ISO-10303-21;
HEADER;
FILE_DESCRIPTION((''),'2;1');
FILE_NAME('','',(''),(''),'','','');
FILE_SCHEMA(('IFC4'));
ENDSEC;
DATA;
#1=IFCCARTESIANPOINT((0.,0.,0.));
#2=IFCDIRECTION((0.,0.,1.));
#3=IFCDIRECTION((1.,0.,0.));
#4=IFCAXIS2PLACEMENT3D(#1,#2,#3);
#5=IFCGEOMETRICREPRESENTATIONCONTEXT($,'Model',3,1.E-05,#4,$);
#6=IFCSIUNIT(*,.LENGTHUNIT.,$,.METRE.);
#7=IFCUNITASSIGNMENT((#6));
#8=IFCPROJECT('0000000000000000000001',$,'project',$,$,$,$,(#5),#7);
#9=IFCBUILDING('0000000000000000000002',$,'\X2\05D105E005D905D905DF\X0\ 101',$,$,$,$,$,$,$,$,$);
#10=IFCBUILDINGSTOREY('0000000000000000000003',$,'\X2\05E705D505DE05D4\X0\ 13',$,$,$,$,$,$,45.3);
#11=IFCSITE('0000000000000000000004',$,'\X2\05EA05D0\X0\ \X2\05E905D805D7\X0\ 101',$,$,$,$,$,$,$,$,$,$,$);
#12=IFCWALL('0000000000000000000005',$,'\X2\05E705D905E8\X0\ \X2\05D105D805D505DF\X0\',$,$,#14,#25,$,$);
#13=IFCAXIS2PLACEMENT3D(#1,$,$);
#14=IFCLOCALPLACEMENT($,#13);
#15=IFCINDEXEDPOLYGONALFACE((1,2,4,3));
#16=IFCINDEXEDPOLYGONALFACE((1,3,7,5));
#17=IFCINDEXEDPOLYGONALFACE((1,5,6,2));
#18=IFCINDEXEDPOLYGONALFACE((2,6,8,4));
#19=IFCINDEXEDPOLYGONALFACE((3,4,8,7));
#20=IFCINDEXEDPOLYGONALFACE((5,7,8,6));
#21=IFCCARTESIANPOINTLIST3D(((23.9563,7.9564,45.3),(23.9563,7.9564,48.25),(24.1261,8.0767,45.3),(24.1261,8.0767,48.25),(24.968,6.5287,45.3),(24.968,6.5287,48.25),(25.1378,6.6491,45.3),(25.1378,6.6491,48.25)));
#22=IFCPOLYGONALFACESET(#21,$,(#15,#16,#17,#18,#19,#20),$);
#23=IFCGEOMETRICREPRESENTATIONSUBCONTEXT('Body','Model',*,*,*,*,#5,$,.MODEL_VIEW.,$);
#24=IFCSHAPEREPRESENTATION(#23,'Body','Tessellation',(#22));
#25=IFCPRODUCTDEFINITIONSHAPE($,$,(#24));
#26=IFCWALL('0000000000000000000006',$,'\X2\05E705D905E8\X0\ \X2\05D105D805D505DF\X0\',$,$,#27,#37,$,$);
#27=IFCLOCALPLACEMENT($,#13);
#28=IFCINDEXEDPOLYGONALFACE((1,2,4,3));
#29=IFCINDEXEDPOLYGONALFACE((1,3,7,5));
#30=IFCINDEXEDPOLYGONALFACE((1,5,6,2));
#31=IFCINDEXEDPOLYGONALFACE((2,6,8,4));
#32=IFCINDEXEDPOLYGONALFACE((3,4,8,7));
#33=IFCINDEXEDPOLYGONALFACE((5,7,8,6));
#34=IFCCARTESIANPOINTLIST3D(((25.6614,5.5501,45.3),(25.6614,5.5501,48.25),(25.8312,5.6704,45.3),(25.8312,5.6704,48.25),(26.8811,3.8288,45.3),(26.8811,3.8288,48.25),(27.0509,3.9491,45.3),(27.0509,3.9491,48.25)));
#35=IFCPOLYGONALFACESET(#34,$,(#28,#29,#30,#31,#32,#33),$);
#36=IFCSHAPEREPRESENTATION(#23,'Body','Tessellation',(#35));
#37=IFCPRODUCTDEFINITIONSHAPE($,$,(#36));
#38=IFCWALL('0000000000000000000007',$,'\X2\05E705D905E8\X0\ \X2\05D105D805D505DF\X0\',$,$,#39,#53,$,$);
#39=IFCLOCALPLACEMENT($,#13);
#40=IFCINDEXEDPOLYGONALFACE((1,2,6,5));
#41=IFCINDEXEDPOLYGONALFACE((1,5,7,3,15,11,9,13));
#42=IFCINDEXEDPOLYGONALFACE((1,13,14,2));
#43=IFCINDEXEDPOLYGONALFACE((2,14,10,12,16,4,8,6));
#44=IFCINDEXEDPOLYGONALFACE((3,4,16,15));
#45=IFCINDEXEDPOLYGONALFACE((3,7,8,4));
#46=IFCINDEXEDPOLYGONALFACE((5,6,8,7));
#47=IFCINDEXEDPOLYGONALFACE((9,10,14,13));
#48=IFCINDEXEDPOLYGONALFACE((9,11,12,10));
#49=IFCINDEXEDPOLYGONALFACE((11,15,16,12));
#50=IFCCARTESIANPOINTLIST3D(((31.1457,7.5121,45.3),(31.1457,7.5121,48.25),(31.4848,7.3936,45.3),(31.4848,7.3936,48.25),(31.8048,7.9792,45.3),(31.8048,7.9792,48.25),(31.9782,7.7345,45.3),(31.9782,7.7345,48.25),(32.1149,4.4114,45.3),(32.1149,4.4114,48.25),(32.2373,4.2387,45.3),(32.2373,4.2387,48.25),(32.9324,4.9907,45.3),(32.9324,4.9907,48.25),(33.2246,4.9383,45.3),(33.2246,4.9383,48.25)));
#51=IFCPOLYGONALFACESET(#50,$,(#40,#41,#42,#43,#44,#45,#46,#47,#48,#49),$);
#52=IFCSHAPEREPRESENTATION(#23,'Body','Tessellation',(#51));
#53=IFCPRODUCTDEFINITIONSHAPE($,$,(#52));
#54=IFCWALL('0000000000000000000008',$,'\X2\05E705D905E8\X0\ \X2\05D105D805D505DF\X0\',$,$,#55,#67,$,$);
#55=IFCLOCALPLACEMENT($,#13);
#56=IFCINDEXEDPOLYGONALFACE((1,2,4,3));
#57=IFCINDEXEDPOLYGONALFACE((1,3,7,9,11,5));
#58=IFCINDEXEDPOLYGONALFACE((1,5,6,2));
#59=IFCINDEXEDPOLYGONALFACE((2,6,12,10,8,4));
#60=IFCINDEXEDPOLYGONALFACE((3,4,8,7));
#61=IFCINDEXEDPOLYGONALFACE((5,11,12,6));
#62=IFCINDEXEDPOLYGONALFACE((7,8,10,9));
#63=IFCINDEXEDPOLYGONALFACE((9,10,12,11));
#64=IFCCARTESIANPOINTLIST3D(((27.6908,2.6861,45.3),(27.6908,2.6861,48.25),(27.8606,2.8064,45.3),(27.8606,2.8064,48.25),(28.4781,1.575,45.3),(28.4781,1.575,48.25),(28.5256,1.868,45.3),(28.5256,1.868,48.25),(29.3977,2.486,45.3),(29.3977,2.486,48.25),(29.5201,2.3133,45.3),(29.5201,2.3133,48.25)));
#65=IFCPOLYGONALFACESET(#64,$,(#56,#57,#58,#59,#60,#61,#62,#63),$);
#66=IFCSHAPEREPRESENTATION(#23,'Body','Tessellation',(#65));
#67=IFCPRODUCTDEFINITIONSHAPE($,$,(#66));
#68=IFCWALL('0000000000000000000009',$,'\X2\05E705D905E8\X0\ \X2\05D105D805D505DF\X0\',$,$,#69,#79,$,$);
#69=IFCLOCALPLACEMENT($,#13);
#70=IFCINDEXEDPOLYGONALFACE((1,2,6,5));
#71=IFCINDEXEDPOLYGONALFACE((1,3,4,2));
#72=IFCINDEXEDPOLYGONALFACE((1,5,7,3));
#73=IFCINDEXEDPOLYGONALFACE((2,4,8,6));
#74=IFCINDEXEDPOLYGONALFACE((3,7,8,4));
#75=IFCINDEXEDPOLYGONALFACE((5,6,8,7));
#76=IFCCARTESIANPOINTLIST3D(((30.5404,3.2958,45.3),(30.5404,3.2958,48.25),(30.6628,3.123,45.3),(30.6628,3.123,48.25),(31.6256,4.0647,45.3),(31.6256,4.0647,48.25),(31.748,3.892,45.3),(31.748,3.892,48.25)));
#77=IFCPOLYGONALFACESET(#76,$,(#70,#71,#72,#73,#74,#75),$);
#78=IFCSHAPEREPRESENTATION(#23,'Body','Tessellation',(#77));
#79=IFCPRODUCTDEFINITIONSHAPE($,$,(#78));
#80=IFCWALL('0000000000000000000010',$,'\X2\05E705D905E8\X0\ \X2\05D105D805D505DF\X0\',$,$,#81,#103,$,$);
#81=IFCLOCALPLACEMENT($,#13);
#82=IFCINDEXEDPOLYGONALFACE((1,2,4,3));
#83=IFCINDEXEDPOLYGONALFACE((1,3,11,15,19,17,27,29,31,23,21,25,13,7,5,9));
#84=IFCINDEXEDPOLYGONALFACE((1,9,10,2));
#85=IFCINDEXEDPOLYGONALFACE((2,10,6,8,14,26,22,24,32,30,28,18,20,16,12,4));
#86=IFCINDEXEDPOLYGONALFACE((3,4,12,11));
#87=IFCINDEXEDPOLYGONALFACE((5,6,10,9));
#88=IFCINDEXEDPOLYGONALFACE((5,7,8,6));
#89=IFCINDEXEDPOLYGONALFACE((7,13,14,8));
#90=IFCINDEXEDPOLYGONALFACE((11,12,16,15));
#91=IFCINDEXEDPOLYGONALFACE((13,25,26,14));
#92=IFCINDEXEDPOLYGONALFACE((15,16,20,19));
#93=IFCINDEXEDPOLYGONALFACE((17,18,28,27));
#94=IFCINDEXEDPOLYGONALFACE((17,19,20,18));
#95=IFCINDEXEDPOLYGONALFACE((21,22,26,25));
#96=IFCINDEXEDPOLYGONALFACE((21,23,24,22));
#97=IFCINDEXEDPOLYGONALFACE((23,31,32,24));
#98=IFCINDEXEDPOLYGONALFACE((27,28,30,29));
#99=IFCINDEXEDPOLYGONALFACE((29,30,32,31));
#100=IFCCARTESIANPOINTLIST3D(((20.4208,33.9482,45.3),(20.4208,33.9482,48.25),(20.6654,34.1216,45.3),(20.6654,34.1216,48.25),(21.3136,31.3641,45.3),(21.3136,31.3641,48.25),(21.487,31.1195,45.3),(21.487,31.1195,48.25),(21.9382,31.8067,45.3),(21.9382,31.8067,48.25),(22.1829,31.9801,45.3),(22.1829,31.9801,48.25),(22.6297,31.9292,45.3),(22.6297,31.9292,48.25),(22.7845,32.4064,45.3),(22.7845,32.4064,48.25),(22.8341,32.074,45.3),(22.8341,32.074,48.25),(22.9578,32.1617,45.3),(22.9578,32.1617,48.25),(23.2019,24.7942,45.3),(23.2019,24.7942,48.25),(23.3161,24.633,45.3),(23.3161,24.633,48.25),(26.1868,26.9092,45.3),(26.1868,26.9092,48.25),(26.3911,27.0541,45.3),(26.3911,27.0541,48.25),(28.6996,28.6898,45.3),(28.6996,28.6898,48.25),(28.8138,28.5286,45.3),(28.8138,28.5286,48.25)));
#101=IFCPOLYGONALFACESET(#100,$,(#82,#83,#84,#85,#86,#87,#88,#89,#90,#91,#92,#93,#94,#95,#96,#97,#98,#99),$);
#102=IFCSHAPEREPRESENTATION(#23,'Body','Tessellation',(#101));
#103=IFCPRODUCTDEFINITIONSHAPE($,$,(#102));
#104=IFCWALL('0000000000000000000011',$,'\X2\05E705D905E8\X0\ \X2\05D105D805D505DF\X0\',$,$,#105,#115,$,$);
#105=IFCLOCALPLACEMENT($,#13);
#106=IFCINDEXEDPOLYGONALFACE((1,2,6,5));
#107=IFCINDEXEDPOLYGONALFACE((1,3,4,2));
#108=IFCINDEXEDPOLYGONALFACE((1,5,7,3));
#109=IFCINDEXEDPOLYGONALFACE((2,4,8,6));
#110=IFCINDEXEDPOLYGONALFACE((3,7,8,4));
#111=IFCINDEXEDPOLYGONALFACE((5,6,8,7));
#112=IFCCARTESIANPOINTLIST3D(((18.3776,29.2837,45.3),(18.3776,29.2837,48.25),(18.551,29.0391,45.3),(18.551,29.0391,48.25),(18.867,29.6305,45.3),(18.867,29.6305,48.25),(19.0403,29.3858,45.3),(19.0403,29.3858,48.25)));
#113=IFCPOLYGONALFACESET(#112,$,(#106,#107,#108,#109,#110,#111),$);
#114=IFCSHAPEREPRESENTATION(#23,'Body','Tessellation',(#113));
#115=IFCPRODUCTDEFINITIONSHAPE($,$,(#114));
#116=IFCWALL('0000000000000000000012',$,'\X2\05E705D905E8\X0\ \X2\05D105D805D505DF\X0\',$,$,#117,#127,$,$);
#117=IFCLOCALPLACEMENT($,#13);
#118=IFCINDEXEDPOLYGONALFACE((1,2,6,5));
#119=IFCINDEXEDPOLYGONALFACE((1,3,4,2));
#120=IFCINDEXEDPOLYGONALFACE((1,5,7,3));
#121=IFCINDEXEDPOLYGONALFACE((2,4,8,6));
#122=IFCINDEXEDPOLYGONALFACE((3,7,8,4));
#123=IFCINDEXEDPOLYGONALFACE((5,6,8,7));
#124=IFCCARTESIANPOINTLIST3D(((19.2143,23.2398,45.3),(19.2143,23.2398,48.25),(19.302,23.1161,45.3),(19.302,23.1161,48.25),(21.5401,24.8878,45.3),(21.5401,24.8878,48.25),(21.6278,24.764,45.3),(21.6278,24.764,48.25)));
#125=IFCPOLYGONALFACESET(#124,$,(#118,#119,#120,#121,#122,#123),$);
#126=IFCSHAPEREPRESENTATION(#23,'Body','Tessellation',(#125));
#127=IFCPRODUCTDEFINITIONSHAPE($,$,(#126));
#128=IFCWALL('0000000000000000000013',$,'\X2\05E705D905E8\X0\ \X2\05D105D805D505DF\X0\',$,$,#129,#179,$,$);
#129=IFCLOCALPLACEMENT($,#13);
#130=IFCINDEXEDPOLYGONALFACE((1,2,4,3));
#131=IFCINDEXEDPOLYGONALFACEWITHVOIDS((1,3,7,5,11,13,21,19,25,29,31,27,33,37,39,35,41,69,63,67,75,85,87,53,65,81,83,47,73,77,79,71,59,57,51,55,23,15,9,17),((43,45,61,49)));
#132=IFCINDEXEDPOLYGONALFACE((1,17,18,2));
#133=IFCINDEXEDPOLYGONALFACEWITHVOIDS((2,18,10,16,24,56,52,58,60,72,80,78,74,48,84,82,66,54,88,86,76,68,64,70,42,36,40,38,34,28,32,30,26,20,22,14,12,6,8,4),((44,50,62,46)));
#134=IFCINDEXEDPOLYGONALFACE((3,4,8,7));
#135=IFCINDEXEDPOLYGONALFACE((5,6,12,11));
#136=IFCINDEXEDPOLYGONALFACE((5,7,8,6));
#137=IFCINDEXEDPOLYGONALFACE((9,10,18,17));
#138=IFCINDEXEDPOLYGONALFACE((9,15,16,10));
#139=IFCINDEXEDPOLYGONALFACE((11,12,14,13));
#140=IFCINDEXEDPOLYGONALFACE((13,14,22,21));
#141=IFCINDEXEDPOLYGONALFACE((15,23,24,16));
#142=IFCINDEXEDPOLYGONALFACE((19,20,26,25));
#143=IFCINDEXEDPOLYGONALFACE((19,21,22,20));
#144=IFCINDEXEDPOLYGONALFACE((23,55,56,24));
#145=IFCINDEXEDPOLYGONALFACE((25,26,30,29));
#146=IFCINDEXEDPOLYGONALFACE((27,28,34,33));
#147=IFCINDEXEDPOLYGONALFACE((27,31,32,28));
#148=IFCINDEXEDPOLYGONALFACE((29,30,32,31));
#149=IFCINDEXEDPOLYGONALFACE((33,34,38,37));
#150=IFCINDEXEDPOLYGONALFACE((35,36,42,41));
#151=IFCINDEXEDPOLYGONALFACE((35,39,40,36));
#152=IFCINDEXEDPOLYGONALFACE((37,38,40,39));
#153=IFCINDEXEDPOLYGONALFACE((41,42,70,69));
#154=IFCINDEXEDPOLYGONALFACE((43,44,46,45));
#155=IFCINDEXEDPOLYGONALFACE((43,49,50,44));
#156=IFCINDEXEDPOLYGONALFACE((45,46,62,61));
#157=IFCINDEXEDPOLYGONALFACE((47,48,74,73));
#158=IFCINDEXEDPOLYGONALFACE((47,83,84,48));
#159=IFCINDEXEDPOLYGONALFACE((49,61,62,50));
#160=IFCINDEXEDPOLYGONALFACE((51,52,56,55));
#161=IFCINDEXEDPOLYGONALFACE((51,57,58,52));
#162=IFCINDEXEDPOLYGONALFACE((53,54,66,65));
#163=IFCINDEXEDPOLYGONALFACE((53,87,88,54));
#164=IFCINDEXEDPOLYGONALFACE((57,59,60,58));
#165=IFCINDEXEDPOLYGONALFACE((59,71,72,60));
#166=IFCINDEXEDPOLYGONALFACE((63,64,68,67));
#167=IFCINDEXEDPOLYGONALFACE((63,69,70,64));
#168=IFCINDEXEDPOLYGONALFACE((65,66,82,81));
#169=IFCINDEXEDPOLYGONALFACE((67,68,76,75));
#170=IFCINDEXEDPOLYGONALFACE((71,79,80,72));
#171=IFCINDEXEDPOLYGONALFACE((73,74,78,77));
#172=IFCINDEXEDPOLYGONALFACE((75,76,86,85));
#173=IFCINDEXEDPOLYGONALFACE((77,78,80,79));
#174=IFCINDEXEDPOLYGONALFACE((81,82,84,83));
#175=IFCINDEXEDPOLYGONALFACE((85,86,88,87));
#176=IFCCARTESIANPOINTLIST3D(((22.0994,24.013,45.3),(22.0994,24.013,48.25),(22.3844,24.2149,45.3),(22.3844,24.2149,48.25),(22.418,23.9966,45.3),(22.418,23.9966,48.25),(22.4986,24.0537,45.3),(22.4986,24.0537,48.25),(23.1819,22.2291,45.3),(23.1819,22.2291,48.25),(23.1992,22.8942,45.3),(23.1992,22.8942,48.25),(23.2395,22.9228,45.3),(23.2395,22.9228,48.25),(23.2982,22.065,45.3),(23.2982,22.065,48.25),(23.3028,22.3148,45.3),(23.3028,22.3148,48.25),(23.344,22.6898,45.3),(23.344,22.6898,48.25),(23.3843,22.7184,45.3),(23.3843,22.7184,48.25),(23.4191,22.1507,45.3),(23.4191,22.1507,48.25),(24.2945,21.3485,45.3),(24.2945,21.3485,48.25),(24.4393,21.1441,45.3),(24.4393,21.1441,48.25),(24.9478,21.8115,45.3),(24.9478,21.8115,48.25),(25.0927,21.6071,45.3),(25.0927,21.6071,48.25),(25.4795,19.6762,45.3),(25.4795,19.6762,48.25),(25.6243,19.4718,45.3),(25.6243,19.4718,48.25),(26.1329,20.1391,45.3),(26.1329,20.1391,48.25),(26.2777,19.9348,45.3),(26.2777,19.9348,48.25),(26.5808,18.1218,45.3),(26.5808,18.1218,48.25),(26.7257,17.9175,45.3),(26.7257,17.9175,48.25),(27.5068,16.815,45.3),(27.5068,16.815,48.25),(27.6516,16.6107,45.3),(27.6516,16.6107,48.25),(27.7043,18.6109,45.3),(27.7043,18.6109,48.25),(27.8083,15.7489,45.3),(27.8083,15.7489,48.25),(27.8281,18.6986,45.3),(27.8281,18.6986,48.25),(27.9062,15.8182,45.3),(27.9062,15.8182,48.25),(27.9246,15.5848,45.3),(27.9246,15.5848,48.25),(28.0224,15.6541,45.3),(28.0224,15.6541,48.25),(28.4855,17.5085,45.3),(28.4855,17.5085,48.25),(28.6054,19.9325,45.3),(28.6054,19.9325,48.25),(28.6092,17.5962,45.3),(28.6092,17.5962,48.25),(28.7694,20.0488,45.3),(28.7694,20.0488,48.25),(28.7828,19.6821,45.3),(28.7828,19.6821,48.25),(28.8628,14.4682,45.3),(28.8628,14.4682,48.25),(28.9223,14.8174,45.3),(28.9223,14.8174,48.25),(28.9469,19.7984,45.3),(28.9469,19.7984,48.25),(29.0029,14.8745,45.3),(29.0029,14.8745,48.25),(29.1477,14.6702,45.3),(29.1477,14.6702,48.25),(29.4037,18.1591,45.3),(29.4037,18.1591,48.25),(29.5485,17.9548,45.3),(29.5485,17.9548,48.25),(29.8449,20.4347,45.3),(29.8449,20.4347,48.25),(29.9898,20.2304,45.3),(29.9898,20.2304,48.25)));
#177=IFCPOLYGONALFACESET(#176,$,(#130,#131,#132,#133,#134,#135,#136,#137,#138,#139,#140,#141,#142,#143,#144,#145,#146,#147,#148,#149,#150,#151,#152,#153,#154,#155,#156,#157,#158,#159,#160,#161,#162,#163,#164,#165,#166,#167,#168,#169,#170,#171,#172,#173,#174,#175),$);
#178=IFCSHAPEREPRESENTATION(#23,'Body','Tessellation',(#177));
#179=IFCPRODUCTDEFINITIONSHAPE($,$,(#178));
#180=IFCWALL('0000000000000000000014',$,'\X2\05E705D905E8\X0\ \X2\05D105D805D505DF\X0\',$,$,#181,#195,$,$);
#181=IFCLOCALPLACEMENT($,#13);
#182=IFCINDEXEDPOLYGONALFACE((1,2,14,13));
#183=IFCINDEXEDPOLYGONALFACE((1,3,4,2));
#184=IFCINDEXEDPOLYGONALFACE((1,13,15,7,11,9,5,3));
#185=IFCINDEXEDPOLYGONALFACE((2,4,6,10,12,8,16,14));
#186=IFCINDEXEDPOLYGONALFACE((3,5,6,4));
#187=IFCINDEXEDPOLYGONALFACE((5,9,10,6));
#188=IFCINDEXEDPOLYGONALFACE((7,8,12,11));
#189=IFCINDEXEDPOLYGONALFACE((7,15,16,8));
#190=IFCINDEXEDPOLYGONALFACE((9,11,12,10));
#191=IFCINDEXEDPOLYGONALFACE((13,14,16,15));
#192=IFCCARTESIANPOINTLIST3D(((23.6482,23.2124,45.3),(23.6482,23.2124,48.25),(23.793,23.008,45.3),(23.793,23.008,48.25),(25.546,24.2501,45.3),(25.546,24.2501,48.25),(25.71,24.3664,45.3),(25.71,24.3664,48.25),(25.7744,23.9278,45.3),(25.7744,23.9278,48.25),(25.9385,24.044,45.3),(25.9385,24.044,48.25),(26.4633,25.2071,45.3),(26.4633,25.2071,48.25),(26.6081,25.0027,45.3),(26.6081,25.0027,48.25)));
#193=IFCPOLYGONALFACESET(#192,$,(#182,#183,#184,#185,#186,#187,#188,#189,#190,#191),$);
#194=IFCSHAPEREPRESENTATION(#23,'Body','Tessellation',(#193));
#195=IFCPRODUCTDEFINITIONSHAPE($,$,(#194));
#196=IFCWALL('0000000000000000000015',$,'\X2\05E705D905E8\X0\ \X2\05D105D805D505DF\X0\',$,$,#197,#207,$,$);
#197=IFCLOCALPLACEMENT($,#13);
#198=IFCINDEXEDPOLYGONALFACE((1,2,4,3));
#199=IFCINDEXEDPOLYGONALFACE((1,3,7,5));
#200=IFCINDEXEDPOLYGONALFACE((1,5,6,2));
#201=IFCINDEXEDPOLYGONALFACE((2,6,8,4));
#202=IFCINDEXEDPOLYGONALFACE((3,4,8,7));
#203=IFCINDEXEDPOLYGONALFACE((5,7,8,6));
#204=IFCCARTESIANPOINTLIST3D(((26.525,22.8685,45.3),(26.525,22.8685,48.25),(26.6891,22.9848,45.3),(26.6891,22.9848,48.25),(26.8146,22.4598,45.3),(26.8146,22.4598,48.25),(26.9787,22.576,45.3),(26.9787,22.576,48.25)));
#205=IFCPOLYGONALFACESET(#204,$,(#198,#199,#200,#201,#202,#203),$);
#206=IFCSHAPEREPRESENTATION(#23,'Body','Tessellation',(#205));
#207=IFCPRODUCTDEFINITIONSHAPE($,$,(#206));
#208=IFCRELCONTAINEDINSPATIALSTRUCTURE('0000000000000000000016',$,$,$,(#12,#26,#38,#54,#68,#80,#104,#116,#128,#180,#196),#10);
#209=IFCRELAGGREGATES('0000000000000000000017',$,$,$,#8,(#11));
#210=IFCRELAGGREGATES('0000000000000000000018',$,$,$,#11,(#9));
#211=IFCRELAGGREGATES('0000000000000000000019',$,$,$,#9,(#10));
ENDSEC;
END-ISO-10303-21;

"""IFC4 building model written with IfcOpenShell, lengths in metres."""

from ifc_helpers import new_model, si_unit, frame, origin_with_axes, context, subcontext, project, spatial, polyline, outline, extrude, element, save


model = new_model("IFC4")

# Units and contexts
model_context = context("Model", 3, precision=1e-05, world=origin_with_axes())
body_context = subcontext(model_context, "Body", "Model", "MODEL_VIEW")
ifc_project = project(units=[si_unit("LENGTHUNIT", "METRE")], contexts=[model_context])

# Site, building, storey
site = spatial("IfcSite", under=ifc_project, Name="תא שטח 101")
building = spatial("IfcBuilding", under=site, Name="בניין 101")
storey = spatial("IfcBuildingStorey", under=building, Name="קומה 13", Elevation=45.3)

# Walls
element("IfcWall", 1, inside=storey, Name="קיר בטון", context=body_context, shape_type="SweptSolid", body=[
    extrude(outline(polyline([(25.1378, 6.6491), (24.1261, 8.0767), (23.9563, 7.9564), (24.968, 6.5287), (25.1378, 6.6491)])), frame((0.0, 0.0, 45.3)), (0.0, 0.0, 1.0), 2.95),
])
element("IfcWall", 2, inside=storey, Name="קיר בטון", context=body_context, shape_type="SweptSolid", body=[
    extrude(outline(polyline([(25.6614, 5.5501), (26.8811, 3.8288), (27.0509, 3.9491), (25.8312, 5.6704), (25.6614, 5.5501)])), frame((0.0, 0.0, 45.3)), (0.0, 0.0, 1.0), 2.95),
])
element("IfcWall", 3, inside=storey, Name="קיר בטון", context=body_context, shape_type="SweptSolid", body=[
    extrude(outline(polyline([(32.2373, 4.2387), (33.2246, 4.9383), (31.4848, 7.3936), (31.9782, 7.7345), (31.8048, 7.9792), (31.1457, 7.5121), (32.9324, 4.9907), (32.1149, 4.4114), (32.2373, 4.2387)])), frame((0.0, 0.0, 45.3)), (0.0, 0.0, 1.0), 2.95),
])
element("IfcWall", 4, inside=storey, Name="קיר בטון", context=body_context, shape_type="SweptSolid", body=[
    extrude(outline(polyline([(28.4781, 1.575), (29.5201, 2.3133), (29.3977, 2.486), (28.5256, 1.868), (27.8606, 2.8064), (27.6908, 2.6861), (28.4781, 1.575)])), frame((0.0, 0.0, 45.3)), (0.0, 0.0, 1.0), 2.95),
])
element("IfcWall", 5, inside=storey, Name="קיר בטון", context=body_context, shape_type="SweptSolid", body=[
    extrude(outline(polyline([(30.5404, 3.2958), (30.6628, 3.123), (31.748, 3.892), (31.6256, 4.0647), (30.5404, 3.2958)])), frame((0.0, 0.0, 45.3)), (0.0, 0.0, 1.0), 2.95),
])
element("IfcWall", 6, inside=storey, Name="קיר בטון", context=body_context, shape_type="SweptSolid", body=[
    extrude(outline(polyline([(21.487, 31.1195), (22.6297, 31.9292), (26.1868, 26.9092), (23.2019, 24.7942), (23.3161, 24.633), (28.8138, 28.5286), (28.6996, 28.6898), (26.3911, 27.0541), (22.8341, 32.074), (22.9578, 32.1617), (22.7845, 32.4064), (22.1829, 31.9801), (20.6654, 34.1216), (20.4208, 33.9482), (21.9382, 31.8067), (21.3136, 31.3641), (21.487, 31.1195)])), frame((0.0, 0.0, 45.3)), (0.0, 0.0, 1.0), 2.95),
])
element("IfcWall", 7, inside=storey, Name="קיר בטון", context=body_context, shape_type="SweptSolid", body=[
    extrude(outline(polyline([(18.867, 29.6305), (18.3776, 29.2837), (18.551, 29.0391), (19.0403, 29.3858), (18.867, 29.6305)])), frame((0.0, 0.0, 45.3)), (0.0, 0.0, 1.0), 2.95),
])
element("IfcWall", 8, inside=storey, Name="קיר בטון", context=body_context, shape_type="SweptSolid", body=[
    extrude(outline(polyline([(21.6278, 24.764), (21.5401, 24.8878), (19.2143, 23.2398), (19.302, 23.1161), (21.6278, 24.764)])), frame((0.0, 0.0, 45.3)), (0.0, 0.0, 1.0), 2.95),
])
element("IfcWall", 9, inside=storey, Name="קיר בטון", context=body_context, shape_type="SweptSolid", body=[
    extrude(outline(polyline([(23.1819, 22.2291), (23.2982, 22.065), (23.4191, 22.1507), (27.9062, 15.8182), (27.8083, 15.7489), (27.9246, 15.5848), (28.0224, 15.6541), (28.8628, 14.4682), (29.1477, 14.6702), (29.0029, 14.8745), (28.9223, 14.8174), (27.6516, 16.6107), (29.5485, 17.9548), (29.4037, 18.1591), (28.6092, 17.5962), (27.8281, 18.6986), (29.9898, 20.2304), (29.8449, 20.4347), (28.9469, 19.7984), (28.7694, 20.0488), (28.6054, 19.9325), (28.7828, 19.6821), (26.5808, 18.1218), (25.6243, 19.4718), (26.2777, 19.9348), (26.1329, 20.1391), (25.4795, 19.6762), (24.4393, 21.1441), (25.0927, 21.6071), (24.9478, 21.8115), (24.2945, 21.3485), (23.344, 22.6898), (23.3843, 22.7184), (23.2395, 22.9228), (23.1992, 22.8942), (22.418, 23.9966), (22.4986, 24.0537), (22.3844, 24.2149), (22.0994, 24.013), (23.3028, 22.3148), (23.1819, 22.2291)]), holes=[polyline([(26.7257, 17.9175), (27.7043, 18.6109), (28.4855, 17.5085), (27.5068, 16.815), (26.7257, 17.9175)])]), frame((0.0, 0.0, 45.3)), (0.0, 0.0, 1.0), 2.95),
])
element("IfcWall", 10, inside=storey, Name="קיר בטון", context=body_context, shape_type="SweptSolid", body=[
    extrude(outline(polyline([(25.7744, 23.9278), (25.9385, 24.044), (25.71, 24.3664), (26.6081, 25.0027), (26.4633, 25.2071), (23.6482, 23.2124), (23.793, 23.008), (25.546, 24.2501), (25.7744, 23.9278)])), frame((0.0, 0.0, 45.3)), (0.0, 0.0, 1.0), 2.95),
])
element("IfcWall", 11, inside=storey, Name="קיר בטון", context=body_context, shape_type="SweptSolid", body=[
    extrude(outline(polyline([(26.525, 22.8685), (26.8146, 22.4598), (26.9787, 22.576), (26.6891, 22.9848), (26.525, 22.8685)])), frame((0.0, 0.0, 45.3)), (0.0, 0.0, 1.0), 2.95),
])

save(model, "model.ifc")
